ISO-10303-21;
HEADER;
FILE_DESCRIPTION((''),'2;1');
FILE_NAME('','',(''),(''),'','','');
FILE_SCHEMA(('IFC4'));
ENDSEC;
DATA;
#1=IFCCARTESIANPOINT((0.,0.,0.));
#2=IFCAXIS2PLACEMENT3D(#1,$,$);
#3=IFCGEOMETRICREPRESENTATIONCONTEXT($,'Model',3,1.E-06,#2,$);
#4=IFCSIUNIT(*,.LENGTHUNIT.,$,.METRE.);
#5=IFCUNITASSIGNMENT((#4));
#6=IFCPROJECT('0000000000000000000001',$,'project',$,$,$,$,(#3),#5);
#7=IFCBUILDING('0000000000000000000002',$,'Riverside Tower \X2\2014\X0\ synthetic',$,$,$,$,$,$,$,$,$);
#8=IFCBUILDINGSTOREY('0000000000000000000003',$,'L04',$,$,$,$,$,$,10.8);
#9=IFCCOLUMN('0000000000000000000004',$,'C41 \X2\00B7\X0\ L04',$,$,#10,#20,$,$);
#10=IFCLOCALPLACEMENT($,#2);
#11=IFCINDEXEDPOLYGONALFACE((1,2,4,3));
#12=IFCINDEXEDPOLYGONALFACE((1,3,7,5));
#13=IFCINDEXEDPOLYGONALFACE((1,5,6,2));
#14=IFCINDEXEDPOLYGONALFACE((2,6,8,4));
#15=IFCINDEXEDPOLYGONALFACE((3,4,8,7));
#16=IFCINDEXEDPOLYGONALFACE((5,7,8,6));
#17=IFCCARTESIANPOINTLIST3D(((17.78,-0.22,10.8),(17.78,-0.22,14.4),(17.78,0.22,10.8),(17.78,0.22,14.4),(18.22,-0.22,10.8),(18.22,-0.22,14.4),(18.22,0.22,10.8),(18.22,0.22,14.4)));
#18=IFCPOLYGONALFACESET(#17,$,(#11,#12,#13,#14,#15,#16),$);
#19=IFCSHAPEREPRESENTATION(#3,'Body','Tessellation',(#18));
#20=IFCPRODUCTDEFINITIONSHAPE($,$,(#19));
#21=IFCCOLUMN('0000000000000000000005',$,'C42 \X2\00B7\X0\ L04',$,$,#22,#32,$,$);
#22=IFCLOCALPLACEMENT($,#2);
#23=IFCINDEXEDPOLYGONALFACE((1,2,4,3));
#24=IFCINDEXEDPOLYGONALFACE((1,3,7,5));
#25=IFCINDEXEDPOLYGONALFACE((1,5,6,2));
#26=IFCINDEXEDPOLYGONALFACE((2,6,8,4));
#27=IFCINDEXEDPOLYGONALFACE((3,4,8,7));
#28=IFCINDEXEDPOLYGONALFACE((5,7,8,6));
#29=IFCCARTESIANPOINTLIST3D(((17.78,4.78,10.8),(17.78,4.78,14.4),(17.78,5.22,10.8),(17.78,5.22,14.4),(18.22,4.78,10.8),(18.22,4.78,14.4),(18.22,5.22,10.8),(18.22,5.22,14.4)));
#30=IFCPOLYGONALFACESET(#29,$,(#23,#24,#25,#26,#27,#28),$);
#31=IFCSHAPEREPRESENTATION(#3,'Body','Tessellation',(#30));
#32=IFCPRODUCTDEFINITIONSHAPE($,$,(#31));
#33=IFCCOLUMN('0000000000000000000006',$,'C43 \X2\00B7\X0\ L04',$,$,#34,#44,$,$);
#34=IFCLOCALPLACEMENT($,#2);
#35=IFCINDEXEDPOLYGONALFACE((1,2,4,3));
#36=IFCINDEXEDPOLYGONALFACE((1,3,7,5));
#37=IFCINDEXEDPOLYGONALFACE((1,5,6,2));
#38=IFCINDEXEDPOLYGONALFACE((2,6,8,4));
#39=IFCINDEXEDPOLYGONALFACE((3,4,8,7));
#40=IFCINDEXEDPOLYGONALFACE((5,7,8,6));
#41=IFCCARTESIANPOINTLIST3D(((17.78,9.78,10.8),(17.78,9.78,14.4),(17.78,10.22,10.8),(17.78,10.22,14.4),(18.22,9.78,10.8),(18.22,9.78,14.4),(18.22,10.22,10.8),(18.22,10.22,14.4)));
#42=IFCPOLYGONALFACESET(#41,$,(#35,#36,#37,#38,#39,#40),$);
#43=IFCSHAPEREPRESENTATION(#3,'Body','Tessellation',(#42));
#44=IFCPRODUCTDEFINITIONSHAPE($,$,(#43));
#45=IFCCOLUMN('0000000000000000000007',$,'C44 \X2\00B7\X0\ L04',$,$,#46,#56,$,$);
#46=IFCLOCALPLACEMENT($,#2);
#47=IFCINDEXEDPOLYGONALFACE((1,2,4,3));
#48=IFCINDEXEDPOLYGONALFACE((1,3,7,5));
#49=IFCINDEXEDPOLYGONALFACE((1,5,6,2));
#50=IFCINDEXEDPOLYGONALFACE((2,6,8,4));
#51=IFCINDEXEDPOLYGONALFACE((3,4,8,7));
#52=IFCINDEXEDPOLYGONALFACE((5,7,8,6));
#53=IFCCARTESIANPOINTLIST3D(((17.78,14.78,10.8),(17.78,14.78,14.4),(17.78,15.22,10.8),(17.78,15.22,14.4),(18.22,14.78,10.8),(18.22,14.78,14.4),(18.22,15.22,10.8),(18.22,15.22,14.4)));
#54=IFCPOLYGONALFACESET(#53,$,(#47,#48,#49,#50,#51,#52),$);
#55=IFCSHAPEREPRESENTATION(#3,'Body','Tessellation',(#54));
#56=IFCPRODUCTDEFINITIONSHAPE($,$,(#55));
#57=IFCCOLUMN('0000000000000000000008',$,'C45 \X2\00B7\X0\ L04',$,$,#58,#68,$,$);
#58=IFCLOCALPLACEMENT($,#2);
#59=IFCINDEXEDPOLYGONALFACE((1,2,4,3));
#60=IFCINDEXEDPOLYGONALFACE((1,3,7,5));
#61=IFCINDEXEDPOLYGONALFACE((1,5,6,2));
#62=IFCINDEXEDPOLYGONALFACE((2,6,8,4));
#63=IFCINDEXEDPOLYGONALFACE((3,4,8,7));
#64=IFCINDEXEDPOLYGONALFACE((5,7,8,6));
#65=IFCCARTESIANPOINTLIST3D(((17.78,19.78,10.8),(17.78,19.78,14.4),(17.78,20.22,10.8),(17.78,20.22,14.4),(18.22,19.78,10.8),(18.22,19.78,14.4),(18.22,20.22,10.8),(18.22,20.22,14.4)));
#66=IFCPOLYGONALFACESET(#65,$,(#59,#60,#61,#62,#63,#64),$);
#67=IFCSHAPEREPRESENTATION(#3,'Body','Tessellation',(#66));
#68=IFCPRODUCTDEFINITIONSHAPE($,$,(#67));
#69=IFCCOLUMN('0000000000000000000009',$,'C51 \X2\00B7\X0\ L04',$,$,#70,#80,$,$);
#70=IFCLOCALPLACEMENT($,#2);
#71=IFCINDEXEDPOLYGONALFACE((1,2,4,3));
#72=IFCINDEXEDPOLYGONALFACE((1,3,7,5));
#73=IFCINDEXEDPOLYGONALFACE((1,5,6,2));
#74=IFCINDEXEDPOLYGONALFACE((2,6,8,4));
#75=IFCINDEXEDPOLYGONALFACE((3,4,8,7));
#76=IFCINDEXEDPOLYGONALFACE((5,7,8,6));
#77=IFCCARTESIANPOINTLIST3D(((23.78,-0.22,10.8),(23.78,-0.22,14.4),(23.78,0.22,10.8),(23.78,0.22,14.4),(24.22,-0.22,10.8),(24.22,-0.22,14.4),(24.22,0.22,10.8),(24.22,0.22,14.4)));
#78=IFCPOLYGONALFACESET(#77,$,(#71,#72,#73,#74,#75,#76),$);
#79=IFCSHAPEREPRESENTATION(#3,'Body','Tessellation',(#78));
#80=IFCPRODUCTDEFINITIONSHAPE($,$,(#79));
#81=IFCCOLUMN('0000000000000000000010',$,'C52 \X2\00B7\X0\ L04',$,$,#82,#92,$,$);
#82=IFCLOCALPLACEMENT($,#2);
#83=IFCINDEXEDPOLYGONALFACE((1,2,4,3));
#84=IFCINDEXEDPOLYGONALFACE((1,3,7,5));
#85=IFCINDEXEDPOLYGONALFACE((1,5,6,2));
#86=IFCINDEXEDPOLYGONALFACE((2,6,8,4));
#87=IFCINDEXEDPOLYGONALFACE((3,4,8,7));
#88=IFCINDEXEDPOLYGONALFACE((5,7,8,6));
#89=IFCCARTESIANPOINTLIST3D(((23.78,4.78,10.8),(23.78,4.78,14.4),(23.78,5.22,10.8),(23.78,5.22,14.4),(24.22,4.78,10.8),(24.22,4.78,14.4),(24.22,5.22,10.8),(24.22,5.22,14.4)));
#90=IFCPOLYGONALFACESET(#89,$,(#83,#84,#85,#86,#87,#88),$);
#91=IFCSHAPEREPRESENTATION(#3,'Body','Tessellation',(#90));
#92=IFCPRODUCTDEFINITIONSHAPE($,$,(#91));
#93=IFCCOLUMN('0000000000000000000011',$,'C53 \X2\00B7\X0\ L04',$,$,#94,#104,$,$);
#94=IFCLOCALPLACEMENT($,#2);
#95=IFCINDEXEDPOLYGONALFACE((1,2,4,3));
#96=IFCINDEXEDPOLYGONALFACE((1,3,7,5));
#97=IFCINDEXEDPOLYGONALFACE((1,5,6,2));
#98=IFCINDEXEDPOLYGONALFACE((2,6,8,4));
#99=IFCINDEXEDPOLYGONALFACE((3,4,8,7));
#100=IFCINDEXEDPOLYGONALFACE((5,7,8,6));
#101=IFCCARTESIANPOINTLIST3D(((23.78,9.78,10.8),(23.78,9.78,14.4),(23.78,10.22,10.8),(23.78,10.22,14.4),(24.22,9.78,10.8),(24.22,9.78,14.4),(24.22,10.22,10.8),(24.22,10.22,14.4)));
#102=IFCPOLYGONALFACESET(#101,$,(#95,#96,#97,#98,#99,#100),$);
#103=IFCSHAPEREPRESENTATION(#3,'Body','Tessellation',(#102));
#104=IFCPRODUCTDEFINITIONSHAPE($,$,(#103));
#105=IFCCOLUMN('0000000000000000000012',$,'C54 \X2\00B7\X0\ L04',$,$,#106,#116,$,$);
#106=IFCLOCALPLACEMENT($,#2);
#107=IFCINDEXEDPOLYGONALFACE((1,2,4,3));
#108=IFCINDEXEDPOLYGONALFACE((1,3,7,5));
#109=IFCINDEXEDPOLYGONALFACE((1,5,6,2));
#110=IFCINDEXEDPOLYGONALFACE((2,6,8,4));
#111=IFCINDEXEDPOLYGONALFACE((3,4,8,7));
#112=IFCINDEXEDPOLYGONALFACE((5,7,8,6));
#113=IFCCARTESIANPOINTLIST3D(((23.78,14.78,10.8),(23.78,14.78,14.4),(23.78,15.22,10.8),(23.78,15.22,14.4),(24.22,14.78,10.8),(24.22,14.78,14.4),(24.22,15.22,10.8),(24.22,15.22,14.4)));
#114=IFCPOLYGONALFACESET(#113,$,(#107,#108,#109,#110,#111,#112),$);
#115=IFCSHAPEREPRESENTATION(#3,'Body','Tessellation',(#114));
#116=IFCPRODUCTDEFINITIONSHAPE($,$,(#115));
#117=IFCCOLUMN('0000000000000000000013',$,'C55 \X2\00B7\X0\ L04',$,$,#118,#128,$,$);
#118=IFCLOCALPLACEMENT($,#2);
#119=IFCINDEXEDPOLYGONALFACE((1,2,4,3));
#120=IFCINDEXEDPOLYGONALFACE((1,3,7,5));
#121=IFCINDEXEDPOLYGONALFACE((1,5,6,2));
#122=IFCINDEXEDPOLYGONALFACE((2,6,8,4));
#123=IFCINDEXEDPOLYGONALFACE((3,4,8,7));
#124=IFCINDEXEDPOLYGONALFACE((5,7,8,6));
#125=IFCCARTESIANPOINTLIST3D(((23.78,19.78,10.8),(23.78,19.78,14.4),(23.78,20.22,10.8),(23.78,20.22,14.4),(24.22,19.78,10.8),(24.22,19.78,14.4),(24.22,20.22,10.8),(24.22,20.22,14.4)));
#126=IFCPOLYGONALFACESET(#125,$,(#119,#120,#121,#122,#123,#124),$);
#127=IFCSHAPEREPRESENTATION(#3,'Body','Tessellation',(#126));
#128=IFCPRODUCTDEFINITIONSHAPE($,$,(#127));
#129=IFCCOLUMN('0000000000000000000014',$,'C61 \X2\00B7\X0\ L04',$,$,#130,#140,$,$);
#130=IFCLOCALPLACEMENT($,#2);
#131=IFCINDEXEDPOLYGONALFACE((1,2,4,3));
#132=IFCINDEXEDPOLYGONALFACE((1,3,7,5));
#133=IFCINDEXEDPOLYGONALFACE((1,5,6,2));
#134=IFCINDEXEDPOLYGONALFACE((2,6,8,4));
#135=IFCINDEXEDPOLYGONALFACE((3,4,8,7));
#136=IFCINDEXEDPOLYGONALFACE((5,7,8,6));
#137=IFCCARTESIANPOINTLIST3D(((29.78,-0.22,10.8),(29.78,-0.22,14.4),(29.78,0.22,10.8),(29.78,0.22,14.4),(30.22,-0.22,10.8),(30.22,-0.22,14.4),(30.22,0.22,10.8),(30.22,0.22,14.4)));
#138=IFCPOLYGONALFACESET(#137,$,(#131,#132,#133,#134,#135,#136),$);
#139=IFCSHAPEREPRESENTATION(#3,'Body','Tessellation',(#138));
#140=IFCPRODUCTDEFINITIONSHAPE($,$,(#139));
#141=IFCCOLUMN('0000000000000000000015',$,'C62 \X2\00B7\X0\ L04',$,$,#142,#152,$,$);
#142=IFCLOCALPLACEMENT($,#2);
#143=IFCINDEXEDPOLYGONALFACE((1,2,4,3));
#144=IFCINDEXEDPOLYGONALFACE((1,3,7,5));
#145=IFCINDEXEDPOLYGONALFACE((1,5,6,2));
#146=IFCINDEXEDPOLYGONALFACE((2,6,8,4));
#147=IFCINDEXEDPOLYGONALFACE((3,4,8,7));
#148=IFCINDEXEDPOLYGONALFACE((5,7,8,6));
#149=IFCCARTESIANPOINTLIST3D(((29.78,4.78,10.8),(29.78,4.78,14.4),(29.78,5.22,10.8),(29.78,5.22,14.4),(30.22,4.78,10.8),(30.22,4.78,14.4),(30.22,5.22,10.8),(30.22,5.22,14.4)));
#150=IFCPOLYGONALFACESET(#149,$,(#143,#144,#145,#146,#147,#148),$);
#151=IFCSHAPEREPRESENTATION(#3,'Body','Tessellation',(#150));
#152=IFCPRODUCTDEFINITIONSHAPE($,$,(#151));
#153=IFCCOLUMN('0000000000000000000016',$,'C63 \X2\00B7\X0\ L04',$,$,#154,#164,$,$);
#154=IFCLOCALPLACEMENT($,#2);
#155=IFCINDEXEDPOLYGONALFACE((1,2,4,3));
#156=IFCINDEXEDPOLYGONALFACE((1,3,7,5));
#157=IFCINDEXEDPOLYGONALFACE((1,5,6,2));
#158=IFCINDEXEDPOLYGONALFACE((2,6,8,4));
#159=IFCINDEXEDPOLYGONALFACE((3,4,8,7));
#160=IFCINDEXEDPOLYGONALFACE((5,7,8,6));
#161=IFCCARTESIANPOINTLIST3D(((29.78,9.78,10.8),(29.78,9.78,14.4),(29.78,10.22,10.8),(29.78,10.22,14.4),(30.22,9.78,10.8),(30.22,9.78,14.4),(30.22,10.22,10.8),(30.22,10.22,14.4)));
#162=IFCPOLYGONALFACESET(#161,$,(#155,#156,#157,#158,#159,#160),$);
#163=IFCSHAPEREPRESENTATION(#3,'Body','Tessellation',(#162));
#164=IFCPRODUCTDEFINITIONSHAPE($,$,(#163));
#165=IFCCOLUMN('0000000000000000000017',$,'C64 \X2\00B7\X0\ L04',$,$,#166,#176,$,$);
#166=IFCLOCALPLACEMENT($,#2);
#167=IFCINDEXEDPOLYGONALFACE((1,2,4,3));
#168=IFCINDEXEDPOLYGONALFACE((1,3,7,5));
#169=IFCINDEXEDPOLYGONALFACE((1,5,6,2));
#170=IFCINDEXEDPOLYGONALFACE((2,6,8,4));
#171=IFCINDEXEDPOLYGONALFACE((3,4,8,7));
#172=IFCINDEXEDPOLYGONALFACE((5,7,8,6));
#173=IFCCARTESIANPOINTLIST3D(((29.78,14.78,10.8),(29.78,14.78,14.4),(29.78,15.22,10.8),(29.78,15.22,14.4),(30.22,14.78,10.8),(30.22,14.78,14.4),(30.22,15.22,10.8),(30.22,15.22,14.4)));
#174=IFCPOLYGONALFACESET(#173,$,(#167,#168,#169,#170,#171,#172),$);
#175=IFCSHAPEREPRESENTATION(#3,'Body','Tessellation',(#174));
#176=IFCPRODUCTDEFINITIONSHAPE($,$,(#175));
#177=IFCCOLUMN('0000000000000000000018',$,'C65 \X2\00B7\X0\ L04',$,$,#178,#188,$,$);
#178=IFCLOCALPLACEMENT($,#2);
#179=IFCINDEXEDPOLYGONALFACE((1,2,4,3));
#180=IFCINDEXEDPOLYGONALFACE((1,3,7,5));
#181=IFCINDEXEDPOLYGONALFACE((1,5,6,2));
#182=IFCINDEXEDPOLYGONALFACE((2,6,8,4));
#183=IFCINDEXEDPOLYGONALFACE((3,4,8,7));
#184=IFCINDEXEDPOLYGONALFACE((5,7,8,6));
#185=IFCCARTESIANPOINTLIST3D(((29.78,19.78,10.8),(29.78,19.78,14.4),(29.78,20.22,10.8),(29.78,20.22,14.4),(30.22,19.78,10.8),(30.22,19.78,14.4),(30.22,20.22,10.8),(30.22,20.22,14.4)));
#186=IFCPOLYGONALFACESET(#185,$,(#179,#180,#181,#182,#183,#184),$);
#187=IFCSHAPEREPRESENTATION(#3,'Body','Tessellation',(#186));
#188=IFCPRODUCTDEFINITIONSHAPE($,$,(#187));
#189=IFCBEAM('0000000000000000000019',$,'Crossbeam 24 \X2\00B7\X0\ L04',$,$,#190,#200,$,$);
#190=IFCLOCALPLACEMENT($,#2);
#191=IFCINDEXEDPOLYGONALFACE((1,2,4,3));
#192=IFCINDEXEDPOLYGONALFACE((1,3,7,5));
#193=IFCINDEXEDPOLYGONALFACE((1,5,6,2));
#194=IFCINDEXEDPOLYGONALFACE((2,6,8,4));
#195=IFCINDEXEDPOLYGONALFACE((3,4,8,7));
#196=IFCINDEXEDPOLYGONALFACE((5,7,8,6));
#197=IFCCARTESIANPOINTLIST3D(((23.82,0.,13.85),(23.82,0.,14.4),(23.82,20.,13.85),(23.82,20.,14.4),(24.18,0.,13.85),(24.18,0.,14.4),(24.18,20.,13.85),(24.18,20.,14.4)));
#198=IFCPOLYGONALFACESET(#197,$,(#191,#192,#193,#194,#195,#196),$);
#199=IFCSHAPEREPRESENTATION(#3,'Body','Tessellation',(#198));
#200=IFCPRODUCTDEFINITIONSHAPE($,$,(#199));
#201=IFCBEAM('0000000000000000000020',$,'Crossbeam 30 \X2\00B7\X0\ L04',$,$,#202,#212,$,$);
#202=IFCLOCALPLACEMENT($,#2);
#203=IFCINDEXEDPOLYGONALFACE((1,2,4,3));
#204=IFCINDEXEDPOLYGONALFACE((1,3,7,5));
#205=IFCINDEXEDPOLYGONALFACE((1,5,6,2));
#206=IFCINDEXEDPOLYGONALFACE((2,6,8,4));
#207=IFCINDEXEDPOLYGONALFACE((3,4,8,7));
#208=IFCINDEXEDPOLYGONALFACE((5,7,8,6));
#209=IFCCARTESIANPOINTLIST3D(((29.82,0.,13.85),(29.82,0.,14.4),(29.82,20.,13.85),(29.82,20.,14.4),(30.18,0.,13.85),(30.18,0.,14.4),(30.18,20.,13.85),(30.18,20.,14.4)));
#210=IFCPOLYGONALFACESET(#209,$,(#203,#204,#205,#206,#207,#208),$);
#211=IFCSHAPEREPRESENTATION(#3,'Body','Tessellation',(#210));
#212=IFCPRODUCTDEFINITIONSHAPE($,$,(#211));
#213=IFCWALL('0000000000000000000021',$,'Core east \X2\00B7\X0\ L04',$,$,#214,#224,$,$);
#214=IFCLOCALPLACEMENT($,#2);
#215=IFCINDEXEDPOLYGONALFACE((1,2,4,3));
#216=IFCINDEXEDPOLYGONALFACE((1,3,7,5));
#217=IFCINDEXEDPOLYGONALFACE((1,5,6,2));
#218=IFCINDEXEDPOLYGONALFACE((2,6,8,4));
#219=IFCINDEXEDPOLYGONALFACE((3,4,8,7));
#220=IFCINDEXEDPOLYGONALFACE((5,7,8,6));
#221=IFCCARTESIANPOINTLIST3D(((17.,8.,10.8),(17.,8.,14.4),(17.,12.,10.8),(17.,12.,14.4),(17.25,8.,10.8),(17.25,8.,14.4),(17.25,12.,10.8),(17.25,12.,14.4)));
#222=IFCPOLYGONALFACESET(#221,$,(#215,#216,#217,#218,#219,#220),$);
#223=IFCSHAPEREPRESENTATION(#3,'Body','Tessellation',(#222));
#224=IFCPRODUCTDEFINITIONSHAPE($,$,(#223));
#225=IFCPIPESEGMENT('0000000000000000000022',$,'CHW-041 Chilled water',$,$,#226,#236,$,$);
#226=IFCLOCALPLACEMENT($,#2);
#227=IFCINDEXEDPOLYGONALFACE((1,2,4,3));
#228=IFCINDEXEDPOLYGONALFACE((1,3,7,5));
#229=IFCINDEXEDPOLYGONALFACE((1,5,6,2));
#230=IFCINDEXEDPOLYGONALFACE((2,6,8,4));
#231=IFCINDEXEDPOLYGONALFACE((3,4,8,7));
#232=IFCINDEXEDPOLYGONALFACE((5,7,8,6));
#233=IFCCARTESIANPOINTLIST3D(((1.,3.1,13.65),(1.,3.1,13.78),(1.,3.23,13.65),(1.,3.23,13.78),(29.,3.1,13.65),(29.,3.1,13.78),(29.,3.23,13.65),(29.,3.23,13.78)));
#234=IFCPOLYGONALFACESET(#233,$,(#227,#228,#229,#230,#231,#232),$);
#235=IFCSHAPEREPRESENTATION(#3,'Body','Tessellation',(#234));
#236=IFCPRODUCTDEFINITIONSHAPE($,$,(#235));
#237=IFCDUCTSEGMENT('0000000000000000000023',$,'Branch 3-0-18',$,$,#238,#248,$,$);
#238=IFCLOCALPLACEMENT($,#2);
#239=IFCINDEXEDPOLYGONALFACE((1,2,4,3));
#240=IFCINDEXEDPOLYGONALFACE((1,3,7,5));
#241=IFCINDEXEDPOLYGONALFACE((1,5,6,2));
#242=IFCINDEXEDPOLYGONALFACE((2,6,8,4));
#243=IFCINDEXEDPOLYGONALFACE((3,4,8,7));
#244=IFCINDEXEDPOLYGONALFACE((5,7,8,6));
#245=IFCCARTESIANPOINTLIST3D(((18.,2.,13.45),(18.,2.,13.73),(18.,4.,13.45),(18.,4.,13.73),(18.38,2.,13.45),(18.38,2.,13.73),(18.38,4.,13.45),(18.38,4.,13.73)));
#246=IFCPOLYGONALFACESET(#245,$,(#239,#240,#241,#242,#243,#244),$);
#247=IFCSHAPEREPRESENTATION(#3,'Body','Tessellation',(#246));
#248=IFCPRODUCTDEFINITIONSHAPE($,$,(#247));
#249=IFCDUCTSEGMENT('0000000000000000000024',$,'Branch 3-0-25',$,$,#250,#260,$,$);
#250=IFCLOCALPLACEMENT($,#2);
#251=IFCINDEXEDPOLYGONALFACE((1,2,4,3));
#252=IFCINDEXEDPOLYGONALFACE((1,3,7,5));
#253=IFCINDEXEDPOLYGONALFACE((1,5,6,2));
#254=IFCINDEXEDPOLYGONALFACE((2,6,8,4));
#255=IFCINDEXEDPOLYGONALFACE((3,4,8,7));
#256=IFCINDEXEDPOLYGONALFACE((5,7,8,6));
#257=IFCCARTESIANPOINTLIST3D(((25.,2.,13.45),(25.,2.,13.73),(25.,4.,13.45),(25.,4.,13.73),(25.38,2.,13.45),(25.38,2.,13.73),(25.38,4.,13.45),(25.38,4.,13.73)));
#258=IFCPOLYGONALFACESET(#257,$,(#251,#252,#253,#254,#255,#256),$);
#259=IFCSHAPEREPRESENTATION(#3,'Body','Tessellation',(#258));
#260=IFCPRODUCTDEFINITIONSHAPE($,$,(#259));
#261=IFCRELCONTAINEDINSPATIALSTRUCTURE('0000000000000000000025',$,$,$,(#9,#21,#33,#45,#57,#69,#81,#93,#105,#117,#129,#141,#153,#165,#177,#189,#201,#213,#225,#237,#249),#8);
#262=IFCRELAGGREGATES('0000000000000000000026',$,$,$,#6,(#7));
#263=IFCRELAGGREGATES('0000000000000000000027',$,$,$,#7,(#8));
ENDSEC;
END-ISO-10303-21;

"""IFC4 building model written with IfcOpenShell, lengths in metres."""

from ifc_helpers import new_model, si_unit, frame, origin, place, context, project, spatial, rectangle, extrude, element, save


model = new_model("IFC4")

# Units and contexts
model_context = context("Model", 3, precision=1e-06, world=origin())
ifc_project = project(units=[si_unit("LENGTHUNIT", "METRE")], contexts=[model_context])

# Building, storey
building = spatial("IfcBuilding", under=ifc_project, Name="Riverside Tower — synthetic")
storey = spatial("IfcBuildingStorey", under=building, Name="L04", Elevation=10.8)

# Columns
for number, where, name in (
    (1, (18.0, 0.0, 10.8), "C41 · L04"),
    (2, (18.0, 5.0, 10.8), "C42 · L04"),
    (3, (18.0, 10.0, 10.8), "C43 · L04"),
    (4, (18.0, 15.0, 10.8), "C44 · L04"),
    (5, (18.0, 20.0, 10.8), "C45 · L04"),
    (6, (24.0, 0.0, 10.8), "C51 · L04"),
    (7, (24.0, 5.0, 10.8), "C52 · L04"),
    (8, (24.0, 10.0, 10.8), "C53 · L04"),
    (9, (24.0, 15.0, 10.8), "C54 · L04"),
    (10, (24.0, 20.0, 10.8), "C55 · L04"),
    (11, (30.0, 0.0, 10.8), "C61 · L04"),
    (12, (30.0, 5.0, 10.8), "C62 · L04"),
    (13, (30.0, 10.0, 10.8), "C63 · L04"),
    (14, (30.0, 15.0, 10.8), "C64 · L04"),
    (15, (30.0, 20.0, 10.8), "C65 · L04"),
):
    element("IfcColumn", number, at=place(None, frame(where)), inside=storey, Name=name, context=model_context, shape_type="SweptSolid", body=[
        extrude(rectangle(XDim=0.44, YDim=0.44), origin(), (0.0, 0.0, 1.0), 3.6),
    ])

# Beams
for number, where, name in (
    (16, (24.0, 10.0, 13.85), "Crossbeam 24 · L04"),
    (17, (30.0, 10.0, 13.85), "Crossbeam 30 · L04"),
):
    element("IfcBeam", number, at=place(None, frame(where)), inside=storey, Name=name, context=model_context, shape_type="SweptSolid", body=[
        extrude(rectangle(XDim=0.36, YDim=20.0), origin(), (0.0, 0.0, 1.0), 0.55),
    ])

# Wall
wall_placement = place(None, frame((17.125, 10.0, 10.8)))
element("IfcWall", 18, at=wall_placement, inside=storey, Name="Core east · L04", context=model_context, shape_type="SweptSolid", body=[
    extrude(rectangle(XDim=0.25, YDim=4.0), origin(), (0.0, 0.0, 1.0), 3.6),
])

# Pipe segment
pipe_segment_1_placement = place(None, frame((15.0, 3.165, 13.65)))
element("IfcPipeSegment", 19, at=pipe_segment_1_placement, inside=storey, Name="CHW-041 Chilled water", context=model_context, shape_type="SweptSolid", body=[
    extrude(rectangle(XDim=28.0, YDim=0.13), origin(), (0.0, 0.0, 1.0), 0.13),
])

# Duct segments
for number, where, name in (
    (20, (18.19, 3.0, 13.45), "Branch 3-0-18"),
    (21, (25.19, 3.0, 13.45), "Branch 3-0-25"),
):
    element("IfcDuctSegment", number, at=place(None, frame(where)), inside=storey, Name=name, context=model_context, shape_type="SweptSolid", body=[
        extrude(rectangle(XDim=0.38, YDim=2.0), origin(), (0.0, 0.0, 1.0), 0.28),
    ])

save(model, "model.ifc")
